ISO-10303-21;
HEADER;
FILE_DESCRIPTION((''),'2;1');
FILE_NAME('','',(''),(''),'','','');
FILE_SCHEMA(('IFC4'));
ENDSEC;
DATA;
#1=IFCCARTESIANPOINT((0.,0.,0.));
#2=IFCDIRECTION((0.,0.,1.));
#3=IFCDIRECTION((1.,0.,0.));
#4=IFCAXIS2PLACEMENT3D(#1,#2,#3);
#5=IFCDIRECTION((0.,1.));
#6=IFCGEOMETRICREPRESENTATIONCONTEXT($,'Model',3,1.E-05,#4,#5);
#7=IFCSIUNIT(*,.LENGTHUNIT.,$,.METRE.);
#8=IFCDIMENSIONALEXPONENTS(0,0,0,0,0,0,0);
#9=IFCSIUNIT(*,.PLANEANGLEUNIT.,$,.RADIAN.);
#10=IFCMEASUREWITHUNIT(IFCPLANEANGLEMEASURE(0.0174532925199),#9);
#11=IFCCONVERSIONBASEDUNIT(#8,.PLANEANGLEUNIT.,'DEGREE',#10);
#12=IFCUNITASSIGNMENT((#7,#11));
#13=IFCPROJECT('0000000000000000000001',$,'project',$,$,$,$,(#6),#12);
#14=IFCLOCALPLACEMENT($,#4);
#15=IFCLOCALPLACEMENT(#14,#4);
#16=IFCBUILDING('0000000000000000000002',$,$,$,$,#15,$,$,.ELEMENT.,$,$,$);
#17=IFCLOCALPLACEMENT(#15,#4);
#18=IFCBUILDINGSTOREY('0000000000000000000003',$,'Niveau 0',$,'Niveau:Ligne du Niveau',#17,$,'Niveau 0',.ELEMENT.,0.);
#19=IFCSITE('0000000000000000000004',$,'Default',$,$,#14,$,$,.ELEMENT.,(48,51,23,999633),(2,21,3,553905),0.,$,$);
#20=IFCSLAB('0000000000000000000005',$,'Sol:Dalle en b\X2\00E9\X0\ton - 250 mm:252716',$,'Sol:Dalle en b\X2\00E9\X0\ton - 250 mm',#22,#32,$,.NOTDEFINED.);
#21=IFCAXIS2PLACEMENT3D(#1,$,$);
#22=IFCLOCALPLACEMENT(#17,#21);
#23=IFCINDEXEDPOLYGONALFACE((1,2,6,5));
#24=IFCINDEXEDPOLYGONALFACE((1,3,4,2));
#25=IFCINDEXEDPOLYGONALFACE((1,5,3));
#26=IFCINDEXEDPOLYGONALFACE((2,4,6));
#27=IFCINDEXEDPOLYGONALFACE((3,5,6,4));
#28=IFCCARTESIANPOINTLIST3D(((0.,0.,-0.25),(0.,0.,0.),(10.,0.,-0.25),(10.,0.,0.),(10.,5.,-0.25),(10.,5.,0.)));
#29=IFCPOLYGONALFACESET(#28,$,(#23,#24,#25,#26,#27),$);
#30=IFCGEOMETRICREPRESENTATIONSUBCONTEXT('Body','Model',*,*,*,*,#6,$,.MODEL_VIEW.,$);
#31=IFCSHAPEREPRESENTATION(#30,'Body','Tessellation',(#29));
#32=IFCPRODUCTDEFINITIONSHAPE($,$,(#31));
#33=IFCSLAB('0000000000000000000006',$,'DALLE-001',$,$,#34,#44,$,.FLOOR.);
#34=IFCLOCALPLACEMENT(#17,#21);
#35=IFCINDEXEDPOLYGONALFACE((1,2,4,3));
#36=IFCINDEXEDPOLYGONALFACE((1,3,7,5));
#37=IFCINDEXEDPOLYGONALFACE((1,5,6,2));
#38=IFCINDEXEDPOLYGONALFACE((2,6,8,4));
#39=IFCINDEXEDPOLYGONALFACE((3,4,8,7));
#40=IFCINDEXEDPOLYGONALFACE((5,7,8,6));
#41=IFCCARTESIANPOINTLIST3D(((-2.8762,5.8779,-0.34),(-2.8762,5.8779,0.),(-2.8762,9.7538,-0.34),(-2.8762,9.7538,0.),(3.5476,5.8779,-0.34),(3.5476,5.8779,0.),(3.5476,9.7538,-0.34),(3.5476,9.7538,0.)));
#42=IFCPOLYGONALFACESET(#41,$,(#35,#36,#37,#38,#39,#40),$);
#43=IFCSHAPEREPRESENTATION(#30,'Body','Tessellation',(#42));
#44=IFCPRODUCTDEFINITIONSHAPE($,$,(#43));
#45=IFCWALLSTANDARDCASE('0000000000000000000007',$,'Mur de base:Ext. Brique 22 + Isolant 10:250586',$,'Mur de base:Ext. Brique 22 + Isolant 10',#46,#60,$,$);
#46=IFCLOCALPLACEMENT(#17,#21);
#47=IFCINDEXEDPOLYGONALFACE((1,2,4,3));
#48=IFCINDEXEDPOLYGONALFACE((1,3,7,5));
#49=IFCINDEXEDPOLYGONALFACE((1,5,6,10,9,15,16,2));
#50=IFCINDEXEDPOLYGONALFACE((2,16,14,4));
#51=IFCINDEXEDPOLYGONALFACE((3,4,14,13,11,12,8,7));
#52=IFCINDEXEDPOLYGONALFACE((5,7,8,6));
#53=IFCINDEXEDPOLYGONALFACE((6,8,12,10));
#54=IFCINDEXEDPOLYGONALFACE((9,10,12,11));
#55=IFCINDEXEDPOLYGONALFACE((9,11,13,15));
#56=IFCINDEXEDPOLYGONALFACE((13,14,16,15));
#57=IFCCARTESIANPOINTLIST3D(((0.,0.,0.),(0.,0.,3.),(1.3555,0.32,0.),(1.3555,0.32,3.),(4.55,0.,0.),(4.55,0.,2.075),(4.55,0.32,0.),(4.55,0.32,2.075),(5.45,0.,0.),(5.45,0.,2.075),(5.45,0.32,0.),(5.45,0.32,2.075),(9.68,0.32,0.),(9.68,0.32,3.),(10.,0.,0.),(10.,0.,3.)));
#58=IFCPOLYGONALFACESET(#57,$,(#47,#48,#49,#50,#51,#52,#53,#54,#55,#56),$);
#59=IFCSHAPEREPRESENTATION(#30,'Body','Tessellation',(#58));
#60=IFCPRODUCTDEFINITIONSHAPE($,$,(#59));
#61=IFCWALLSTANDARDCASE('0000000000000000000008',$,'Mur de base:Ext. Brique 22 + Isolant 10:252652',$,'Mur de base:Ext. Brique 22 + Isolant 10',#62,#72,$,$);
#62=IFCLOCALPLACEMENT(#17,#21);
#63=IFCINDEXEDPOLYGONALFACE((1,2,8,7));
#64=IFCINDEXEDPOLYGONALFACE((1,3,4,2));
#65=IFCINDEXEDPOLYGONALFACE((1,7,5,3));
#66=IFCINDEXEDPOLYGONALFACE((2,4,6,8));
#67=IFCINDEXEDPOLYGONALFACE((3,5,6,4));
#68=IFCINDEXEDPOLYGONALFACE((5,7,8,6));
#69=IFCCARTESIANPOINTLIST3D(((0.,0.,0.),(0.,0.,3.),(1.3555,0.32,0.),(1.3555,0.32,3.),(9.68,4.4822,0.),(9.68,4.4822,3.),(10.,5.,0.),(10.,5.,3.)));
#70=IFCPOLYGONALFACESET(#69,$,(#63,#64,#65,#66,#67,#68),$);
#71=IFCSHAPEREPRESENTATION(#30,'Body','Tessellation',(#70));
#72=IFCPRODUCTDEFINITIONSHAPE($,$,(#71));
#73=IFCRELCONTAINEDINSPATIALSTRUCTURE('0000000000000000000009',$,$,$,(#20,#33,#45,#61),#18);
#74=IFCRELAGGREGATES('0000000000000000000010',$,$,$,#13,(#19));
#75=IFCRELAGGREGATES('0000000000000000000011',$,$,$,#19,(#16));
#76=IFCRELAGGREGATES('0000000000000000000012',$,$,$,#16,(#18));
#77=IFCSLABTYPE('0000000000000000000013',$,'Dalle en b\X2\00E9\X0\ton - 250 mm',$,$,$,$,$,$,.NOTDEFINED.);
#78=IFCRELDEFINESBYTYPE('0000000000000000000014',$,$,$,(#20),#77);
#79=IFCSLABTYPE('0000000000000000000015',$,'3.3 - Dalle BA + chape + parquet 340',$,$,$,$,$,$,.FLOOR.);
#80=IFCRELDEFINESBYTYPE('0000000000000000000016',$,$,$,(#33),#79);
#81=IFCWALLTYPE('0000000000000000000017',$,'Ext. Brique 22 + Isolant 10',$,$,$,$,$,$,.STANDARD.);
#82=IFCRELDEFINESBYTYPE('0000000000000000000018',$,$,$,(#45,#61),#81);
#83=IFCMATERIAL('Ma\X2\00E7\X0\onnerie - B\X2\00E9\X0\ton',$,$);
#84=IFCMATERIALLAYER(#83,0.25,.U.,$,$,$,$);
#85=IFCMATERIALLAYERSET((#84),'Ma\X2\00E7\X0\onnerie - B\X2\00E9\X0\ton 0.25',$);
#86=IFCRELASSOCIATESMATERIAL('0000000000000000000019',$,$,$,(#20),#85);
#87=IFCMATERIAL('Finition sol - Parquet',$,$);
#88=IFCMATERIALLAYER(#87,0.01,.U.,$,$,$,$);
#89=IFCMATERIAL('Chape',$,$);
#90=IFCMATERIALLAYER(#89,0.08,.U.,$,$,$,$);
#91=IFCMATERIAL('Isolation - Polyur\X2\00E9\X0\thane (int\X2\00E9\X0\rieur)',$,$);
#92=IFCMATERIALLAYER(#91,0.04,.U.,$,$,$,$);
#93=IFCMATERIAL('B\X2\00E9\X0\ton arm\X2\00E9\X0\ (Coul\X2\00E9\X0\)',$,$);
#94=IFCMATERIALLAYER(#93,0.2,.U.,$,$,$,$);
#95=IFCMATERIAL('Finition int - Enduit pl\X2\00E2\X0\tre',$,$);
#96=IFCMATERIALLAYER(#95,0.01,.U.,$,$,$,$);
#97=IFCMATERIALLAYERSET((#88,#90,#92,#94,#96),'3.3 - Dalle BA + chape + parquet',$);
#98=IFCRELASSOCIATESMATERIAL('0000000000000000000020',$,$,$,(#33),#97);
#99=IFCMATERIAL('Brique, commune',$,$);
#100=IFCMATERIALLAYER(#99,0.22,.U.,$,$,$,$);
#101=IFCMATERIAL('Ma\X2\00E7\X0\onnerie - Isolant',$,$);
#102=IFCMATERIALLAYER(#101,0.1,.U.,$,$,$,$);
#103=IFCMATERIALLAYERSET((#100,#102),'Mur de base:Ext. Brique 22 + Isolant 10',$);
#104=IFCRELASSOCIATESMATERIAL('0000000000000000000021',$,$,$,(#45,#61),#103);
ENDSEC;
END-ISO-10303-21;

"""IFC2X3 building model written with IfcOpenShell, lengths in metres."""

from ifc_helpers import new_model, entity, si_unit, converted_unit, direction, frame, origin_with_axes, place, context, subcontext, project, spatial, polyline, outline, extrude, material, layer, layer_set, layer_usage, type_object, element, save


model = new_model("IFC2X3")

# Units and contexts
model_context = context("Model", 3, precision=1e-05, world=origin_with_axes(), true_north=direction((0.0, 1.0)))
body_context = subcontext(model_context, "Body", "Model", "MODEL_VIEW")
ifc_project = project(units=[si_unit("LENGTHUNIT", "METRE"), converted_unit("PLANEANGLEUNIT", "DEGREE", entity("IfcPlaneAngleMeasure", 0.0174532925199), si_unit("PLANEANGLEUNIT", "RADIAN"), dimensions=[0, 0, 0, 0, 0, 0, 0])], contexts=[model_context])

# Site, building, storey
site_placement = place(None, origin_with_axes())
site = spatial("IfcSite", under=ifc_project, at=site_placement, Name="Default", CompositionType="ELEMENT", RefLatitude=(48, 51, 23, 999633), RefLongitude=(2, 21, 3, 553905), RefElevation=0.0)
building_placement = place(site_placement, origin_with_axes())
building = spatial("IfcBuilding", under=site, at=building_placement, CompositionType="ELEMENT")
storey_placement = place(building_placement, origin_with_axes())
storey = spatial("IfcBuildingStorey", under=building, at=storey_placement, Name="Niveau 0", ObjectType="Niveau:Ligne du Niveau", LongName="Niveau 0", CompositionType="ELEMENT", Elevation=0.0)

# Slabs
ifc_material_1 = material(Name="Maçonnerie - Béton")
ifc_layer_1 = layer(ifc_material_1, 0.25, ventilated="UNKNOWN")
ifc_layer_set_1 = layer_set([ifc_layer_1], Name="Maçonnerie - Béton 0.25")
ifc_layer_usage_1 = layer_usage(ifc_layer_set_1, "AXIS3", "NEGATIVE", 0.25)
slab_type_1 = type_object("IfcSlabType", Name="Dalle en béton - 250 mm", PredefinedType="NOTDEFINED")
slab_1_placement = place(storey_placement, frame((10.0, 0.0, 0.0), z_axis=(0.0, 0.0, 1.0), x_axis=(1.0, 0.0, 0.0)))
element("IfcSlab", 1, at=slab_1_placement, inside=storey, type_object=slab_type_1, material=ifc_layer_usage_1, Name="Sol:Dalle en béton - 250 mm:252716", ObjectType="Sol:Dalle en béton - 250 mm", PredefinedType="NOTDEFINED", context=body_context, shape_type="SweptSolid", body=[
    extrude(outline(polyline([(0.0, 0.0), (0.0, 5.0), (-10.0, 0.0), (0.0, 0.0)])), frame((0.0, 0.0, -0.25), z_axis=(0.0, 0.0, 1.0), x_axis=(1.0, 0.0, 0.0)), (0.0, 0.0, 1.0), 0.25),
])
ifc_material_2 = material(Name="Finition sol - Parquet")
ifc_layer_2 = layer(ifc_material_2, 0.01, ventilated="UNKNOWN")
ifc_material_3 = material(Name="Chape")
ifc_layer_3 = layer(ifc_material_3, 0.08, ventilated="UNKNOWN")
ifc_material_4 = material(Name="Isolation - Polyuréthane (intérieur)")
ifc_layer_4 = layer(ifc_material_4, 0.04, ventilated="UNKNOWN")
ifc_material_5 = material(Name="Béton armé (Coulé)")
ifc_layer_5 = layer(ifc_material_5, 0.2, ventilated="UNKNOWN")
ifc_material_6 = material(Name="Finition int - Enduit plâtre")
ifc_layer_6 = layer(ifc_material_6, 0.01, ventilated="UNKNOWN")
ifc_layer_set_2 = layer_set([ifc_layer_2, ifc_layer_3, ifc_layer_4, ifc_layer_5, ifc_layer_6], Name="3.3 - Dalle BA + chape + parquet")
ifc_layer_usage_2 = layer_usage(ifc_layer_set_2, "AXIS3", "NEGATIVE", 0.34)
slab_type_2 = type_object("IfcSlabType", Name="3.3 - Dalle BA + chape + parquet 340", PredefinedType="FLOOR")
slab_2_placement = place(storey_placement, frame((-2.8762, 5.8779, 0.0), z_axis=(0.0, 0.0, 1.0), x_axis=(1.0, 0.0, 0.0)))
element("IfcSlab", 2, at=slab_2_placement, inside=storey, type_object=slab_type_2, material=ifc_layer_usage_2, Name="DALLE-001", PredefinedType="FLOOR", context=body_context, shape_type="SweptSolid", body=[
    extrude(outline(polyline([(0.0, 0.0), (6.4237, 0.0), (6.4237, 3.8758), (0.0, 3.8758), (0.0, 0.0)])), frame((0.0, 0.0, -0.34), z_axis=(0.0, 0.0, 1.0), x_axis=(1.0, 0.0, 0.0)), (0.0, 0.0, 1.0), 0.34),
])

# Wall, opening
ifc_material_7 = material(Name="Brique, commune")
ifc_layer_7 = layer(ifc_material_7, 0.22, ventilated="UNKNOWN")
ifc_material_8 = material(Name="Maçonnerie - Isolant")
ifc_layer_8 = layer(ifc_material_8, 0.1, ventilated="UNKNOWN")
ifc_layer_set_3 = layer_set([ifc_layer_7, ifc_layer_8], Name="Mur de base:Ext. Brique 22 + Isolant 10")
ifc_layer_usage_3 = layer_usage(ifc_layer_set_3, "AXIS2", "POSITIVE", -0.16)
wall_type_1 = type_object("IfcWallType", Name="Ext. Brique 22 + Isolant 10", PredefinedType="STANDARD")
wall_1_placement = place(storey_placement, frame((9.84, 0.16, 0.0), z_axis=(0.0, 0.0, 1.0), x_axis=(-1.0, 0.0, 0.0)))
wall_1 = element("IfcWallStandardCase", 3, at=wall_1_placement, inside=storey, type_object=wall_type_1, material=ifc_layer_usage_3, Name="Mur de base:Ext. Brique 22 + Isolant 10:250586", ObjectType="Mur de base:Ext. Brique 22 + Isolant 10", context=body_context, shape_type="SweptSolid", body=[
    extrude(outline(polyline([(0.16, -0.16), (8.4845, -0.16), (9.84, 0.16), (-0.16, 0.16), (0.16, -0.16)])), origin_with_axes(), (0.0, 0.0, 1.0), 3.0),
])
opening_1_placement = place(wall_1_placement, frame((4.84, 0.0, 0.0), z_axis=(0.0, 0.0, 1.0), x_axis=(1.0, 0.0, 0.0)))
element("IfcOpeningElement", 4, at=opening_1_placement, cuts=wall_1, context=body_context, shape_type="SweptSolid", body=[
    extrude(outline(polyline([(0.45, 0.0), (0.45, 2.075), (-0.45, 2.075), (-0.45, 0.0), (0.45, 0.0)])), frame((0.0, 0.16, 0.0), z_axis=(0.0, -1.0, 0.0), x_axis=(1.0, 0.0, 0.0)), (0.0, 0.0, 1.0), 0.32),
])

# Wall
ifc_layer_usage_4 = layer_usage(ifc_layer_set_3, "AXIS2", "POSITIVE", -0.16)
wall_2_placement = place(storey_placement, frame((0.6778, 0.16, 0.0), z_axis=(0.0, 0.0, 1.0), x_axis=(0.894427, 0.447214, 0.0)))
element("IfcWallStandardCase", 5, at=wall_2_placement, inside=storey, type_object=wall_type_1, material=ifc_layer_usage_4, Name="Mur de base:Ext. Brique 22 + Isolant 10:252652", ObjectType="Mur de base:Ext. Brique 22 + Isolant 10", context=body_context, shape_type="SweptSolid", body=[
    extrude(outline(polyline([(0.6778, -0.16), (9.9848, -0.16), (10.5026, 0.16), (-0.6778, 0.16), (0.6778, -0.16)])), origin_with_axes(), (0.0, 0.0, 1.0), 3.0),
])

save(model, "model.ifc")
